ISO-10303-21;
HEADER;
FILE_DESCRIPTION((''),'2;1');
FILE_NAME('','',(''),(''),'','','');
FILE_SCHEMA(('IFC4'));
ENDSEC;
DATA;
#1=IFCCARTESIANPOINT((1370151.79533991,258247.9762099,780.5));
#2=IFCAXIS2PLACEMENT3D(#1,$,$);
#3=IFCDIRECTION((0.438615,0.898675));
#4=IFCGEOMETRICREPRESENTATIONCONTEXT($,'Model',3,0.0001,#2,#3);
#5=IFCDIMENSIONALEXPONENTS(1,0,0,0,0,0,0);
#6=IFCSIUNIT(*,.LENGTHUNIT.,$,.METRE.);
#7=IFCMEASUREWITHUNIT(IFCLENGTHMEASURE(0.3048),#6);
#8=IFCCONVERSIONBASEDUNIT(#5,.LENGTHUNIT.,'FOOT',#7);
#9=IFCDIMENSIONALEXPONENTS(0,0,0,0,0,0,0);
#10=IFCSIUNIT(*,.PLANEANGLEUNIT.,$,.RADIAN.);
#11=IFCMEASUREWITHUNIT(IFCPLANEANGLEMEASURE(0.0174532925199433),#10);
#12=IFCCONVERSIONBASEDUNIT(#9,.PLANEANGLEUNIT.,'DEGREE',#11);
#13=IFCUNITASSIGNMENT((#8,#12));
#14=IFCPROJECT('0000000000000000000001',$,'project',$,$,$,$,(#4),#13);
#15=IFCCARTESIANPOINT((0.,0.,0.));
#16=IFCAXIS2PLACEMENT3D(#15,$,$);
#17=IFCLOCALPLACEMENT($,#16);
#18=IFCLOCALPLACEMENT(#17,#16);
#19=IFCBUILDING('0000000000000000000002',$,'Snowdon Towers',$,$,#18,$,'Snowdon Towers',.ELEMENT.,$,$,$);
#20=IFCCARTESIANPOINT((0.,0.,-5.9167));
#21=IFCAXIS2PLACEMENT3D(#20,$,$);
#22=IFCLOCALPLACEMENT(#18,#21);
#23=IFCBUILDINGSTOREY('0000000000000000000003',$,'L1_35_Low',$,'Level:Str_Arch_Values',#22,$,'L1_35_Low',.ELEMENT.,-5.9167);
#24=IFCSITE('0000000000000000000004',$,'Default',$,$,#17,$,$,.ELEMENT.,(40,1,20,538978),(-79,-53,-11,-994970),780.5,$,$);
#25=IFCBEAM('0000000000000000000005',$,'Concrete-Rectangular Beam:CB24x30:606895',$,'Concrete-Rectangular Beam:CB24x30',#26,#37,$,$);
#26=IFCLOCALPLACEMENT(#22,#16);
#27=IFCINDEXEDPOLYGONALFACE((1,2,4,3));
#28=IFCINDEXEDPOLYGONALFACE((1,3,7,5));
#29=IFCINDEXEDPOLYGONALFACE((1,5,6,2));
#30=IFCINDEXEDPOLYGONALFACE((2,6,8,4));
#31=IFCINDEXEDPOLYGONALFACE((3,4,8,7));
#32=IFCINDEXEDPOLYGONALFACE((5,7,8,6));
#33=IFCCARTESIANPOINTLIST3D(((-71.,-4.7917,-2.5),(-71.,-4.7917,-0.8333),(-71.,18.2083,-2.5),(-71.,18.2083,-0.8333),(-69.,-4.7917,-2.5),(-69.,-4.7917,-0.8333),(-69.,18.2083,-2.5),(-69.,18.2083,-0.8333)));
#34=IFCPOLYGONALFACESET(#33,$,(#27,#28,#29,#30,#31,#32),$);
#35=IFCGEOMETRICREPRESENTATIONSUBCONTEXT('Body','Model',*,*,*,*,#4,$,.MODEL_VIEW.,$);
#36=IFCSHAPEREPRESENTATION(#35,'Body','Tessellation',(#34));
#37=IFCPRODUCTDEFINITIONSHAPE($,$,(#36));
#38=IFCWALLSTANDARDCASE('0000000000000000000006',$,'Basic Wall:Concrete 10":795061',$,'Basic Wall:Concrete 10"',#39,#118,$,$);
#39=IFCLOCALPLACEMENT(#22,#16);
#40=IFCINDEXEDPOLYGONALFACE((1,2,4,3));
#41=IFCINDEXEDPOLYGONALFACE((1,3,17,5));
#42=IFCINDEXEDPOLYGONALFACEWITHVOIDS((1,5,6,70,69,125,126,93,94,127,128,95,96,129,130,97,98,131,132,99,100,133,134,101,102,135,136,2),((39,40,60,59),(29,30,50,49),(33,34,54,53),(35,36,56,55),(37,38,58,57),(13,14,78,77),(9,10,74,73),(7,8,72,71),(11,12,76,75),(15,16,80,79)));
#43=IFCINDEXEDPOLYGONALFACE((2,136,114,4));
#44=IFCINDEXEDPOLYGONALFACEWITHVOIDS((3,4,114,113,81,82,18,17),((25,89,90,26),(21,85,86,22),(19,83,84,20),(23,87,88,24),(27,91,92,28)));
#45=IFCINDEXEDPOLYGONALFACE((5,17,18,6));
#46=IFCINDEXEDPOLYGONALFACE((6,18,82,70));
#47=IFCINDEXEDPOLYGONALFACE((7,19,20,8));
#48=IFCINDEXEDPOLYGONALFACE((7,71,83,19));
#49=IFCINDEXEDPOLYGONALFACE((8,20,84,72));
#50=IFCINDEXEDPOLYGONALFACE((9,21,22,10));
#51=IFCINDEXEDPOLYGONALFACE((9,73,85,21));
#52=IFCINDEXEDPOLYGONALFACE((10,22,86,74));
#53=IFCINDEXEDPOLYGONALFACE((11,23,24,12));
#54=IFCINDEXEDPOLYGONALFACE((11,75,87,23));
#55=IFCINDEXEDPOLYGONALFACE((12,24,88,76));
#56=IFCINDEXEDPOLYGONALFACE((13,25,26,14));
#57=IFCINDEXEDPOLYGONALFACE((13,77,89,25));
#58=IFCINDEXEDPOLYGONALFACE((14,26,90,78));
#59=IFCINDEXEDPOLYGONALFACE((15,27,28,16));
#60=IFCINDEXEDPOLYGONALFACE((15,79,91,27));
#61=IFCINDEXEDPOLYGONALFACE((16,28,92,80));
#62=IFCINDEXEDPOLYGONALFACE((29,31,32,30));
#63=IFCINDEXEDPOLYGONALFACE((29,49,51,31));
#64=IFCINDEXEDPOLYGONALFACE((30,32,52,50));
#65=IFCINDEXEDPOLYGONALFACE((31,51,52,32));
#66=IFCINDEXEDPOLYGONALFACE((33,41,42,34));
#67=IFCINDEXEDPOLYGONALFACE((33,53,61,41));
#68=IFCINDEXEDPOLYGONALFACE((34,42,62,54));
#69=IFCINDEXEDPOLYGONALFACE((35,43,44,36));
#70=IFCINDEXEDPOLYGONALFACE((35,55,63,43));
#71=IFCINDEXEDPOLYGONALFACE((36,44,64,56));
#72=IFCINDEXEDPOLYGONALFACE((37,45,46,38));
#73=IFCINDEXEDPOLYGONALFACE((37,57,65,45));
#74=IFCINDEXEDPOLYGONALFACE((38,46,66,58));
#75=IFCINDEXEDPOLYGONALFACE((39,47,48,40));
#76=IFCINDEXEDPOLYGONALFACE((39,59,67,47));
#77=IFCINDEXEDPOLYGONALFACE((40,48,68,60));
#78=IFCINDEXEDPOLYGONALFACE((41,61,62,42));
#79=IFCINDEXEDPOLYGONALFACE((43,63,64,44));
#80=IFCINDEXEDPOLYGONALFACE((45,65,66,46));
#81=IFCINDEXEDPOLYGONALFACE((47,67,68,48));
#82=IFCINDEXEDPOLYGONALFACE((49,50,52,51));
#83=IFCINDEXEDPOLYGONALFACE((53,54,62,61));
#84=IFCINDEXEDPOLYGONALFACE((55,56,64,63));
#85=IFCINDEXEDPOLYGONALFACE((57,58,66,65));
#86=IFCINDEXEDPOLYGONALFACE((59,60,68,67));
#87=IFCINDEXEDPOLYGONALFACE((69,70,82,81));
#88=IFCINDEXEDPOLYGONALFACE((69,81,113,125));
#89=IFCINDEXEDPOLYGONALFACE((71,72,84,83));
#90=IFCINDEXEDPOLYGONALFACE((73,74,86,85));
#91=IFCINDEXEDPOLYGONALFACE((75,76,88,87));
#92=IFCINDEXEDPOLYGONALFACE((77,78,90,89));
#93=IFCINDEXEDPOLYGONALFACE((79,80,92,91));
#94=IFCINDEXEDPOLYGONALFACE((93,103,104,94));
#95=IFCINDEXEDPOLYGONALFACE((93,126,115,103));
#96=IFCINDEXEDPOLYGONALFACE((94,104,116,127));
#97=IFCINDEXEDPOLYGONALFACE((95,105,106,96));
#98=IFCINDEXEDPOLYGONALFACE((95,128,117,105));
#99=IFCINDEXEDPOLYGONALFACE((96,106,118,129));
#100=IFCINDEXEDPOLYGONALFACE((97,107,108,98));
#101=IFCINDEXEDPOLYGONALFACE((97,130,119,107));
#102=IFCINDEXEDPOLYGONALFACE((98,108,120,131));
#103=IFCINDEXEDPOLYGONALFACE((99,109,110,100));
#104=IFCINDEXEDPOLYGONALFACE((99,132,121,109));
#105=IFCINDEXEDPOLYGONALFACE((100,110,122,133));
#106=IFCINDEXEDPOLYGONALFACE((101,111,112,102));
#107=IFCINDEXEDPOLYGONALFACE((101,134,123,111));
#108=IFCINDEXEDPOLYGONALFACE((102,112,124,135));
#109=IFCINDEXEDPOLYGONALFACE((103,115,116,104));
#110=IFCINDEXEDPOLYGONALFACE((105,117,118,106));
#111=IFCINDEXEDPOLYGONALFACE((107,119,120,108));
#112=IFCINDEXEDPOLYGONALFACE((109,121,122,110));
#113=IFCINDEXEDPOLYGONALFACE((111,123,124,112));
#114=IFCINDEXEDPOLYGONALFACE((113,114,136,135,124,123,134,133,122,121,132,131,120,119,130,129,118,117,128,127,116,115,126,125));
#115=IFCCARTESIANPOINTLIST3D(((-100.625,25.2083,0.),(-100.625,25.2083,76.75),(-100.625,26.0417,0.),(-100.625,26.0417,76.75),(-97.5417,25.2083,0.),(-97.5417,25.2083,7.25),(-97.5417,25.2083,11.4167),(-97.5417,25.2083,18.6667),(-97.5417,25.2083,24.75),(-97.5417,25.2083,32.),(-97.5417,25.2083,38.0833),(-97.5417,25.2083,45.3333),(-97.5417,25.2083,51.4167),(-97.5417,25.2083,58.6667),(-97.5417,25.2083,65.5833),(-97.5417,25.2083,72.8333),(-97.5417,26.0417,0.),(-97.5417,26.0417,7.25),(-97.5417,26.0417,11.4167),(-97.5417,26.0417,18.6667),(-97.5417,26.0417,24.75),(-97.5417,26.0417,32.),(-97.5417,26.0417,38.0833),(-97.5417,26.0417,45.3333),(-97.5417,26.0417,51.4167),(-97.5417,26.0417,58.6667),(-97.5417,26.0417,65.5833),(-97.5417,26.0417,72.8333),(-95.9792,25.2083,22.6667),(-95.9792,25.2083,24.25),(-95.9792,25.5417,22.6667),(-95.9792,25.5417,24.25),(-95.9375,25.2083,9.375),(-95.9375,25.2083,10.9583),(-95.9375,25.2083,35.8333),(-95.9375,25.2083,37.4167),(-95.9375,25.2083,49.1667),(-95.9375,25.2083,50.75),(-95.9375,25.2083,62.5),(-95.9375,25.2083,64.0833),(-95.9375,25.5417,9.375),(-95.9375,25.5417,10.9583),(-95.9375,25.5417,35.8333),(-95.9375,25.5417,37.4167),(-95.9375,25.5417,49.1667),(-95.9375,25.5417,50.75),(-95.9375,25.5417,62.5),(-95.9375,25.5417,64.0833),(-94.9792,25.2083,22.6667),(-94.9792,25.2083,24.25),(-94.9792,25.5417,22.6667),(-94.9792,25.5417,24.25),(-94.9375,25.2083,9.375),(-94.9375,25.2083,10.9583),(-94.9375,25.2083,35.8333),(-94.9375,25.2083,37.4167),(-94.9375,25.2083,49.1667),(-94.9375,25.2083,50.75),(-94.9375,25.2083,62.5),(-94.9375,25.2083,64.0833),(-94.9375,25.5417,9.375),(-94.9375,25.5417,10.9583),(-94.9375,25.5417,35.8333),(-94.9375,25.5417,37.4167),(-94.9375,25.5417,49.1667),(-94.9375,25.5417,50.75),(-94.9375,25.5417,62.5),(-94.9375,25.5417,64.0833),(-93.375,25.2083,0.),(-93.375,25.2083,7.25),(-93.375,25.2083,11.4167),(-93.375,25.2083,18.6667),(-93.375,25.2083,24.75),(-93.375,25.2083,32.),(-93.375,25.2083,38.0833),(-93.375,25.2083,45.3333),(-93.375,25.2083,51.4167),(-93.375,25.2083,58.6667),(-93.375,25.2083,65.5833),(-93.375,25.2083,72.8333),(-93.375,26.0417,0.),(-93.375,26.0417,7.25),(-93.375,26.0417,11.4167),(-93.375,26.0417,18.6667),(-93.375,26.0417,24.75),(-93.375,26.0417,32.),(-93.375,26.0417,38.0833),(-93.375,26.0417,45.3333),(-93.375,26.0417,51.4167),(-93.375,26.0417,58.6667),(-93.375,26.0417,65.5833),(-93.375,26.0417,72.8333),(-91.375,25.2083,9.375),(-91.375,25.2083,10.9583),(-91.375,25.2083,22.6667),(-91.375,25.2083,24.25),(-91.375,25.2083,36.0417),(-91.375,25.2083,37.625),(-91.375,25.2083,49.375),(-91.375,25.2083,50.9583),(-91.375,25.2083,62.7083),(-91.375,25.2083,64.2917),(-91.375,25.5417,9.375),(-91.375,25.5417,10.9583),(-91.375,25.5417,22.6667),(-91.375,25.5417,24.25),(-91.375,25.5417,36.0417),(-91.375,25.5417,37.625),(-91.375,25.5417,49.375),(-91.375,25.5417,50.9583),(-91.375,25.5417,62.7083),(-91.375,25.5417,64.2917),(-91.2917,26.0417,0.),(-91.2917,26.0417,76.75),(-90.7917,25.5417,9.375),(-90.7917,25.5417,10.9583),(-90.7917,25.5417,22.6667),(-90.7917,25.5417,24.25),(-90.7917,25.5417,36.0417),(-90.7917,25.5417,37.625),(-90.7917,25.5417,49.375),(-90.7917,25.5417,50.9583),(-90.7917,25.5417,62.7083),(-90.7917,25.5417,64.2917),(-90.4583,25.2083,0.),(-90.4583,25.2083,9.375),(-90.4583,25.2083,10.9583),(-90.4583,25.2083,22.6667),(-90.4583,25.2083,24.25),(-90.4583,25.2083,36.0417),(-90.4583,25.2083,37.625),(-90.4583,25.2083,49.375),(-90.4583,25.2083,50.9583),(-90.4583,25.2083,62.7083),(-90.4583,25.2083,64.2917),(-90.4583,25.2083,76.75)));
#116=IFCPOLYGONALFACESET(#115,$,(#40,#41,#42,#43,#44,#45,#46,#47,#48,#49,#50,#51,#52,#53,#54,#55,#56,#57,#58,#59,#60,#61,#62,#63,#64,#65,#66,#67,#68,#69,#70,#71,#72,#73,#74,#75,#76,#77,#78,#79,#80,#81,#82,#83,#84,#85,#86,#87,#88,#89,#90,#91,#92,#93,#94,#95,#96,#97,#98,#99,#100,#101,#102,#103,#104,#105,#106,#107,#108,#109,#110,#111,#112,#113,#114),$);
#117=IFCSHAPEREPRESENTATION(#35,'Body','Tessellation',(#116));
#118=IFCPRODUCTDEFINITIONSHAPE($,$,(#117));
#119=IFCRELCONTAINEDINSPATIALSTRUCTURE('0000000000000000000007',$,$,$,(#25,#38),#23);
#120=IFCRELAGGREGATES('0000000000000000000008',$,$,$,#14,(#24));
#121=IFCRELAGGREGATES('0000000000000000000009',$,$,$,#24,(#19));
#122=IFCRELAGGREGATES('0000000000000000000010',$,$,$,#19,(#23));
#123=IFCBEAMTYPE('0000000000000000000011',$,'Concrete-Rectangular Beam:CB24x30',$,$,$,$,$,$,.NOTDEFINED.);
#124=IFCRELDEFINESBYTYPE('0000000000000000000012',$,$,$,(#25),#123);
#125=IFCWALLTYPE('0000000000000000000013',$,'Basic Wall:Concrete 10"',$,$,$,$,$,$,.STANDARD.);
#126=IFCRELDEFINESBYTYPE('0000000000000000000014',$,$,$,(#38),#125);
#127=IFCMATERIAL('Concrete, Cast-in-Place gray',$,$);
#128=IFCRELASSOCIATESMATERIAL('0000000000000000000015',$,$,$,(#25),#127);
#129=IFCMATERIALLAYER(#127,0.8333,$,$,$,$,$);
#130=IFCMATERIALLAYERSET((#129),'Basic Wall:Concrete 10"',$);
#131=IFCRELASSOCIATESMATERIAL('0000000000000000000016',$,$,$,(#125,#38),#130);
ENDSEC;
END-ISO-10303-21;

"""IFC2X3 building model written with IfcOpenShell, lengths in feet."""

from ifc_helpers import new_model, entity, si_unit, converted_unit, direction, frame, frame_2d, origin, place, context, subcontext, project, spatial, polyline, rectangle, outline, extrude, material, layer, layer_set, layer_usage, type_object, element, save


model = new_model("IFC2X3")

# Units and contexts
model_context = context("Model", 3, precision=0.0001, world=frame((1370151.79533991, 258247.9762099, 780.5)), true_north=direction((0.438615, 0.898675)))
body_context = subcontext(model_context, "Body", "Model", "MODEL_VIEW")
ifc_project = project(units=[converted_unit("LENGTHUNIT", "FOOT", entity("IfcLengthMeasure", 0.3048), si_unit("LENGTHUNIT", "METRE"), dimensions=[1, 0, 0, 0, 0, 0, 0]), converted_unit("PLANEANGLEUNIT", "DEGREE", entity("IfcPlaneAngleMeasure", 0.0174532925199433), si_unit("PLANEANGLEUNIT", "RADIAN"), dimensions=[0, 0, 0, 0, 0, 0, 0])], contexts=[model_context])

# Site, building, storey
site_placement = place(None, origin())
site = spatial("IfcSite", under=ifc_project, at=site_placement, Name="Default", CompositionType="ELEMENT", RefLatitude=(40, 1, 20, 538978), RefLongitude=(-79, -53, -11, -994970), RefElevation=780.5)
building_placement = place(site_placement, origin())
building = spatial("IfcBuilding", under=site, at=building_placement, Name="Snowdon Towers", LongName="Snowdon Towers", CompositionType="ELEMENT")
storey_placement = place(building_placement, frame((0.0, 0.0, -5.9167)))
storey = spatial("IfcBuildingStorey", under=building, at=storey_placement, Name="L1_35_Low", ObjectType="Level:Str_Arch_Values", LongName="L1_35_Low", CompositionType="ELEMENT", Elevation=-5.9167)

# Beam
ifc_material_1 = material(Name="Concrete, Cast-in-Place gray")
beam_type_1 = type_object("IfcBeamType", Name="Concrete-Rectangular Beam:CB24x30", PredefinedType="NOTDEFINED")
beam_1_placement = place(storey_placement, frame((-70.0, -5.7917, 0.0), z_axis=(0.0, 0.0, 1.0), x_axis=(0.0, 1.0, 0.0)))
element("IfcBeam", 1, at=beam_1_placement, inside=storey, type_object=beam_type_1, material=ifc_material_1, Name="Concrete-Rectangular Beam:CB24x30:606895", ObjectType="Concrete-Rectangular Beam:CB24x30", context=body_context, shape_type="SweptSolid", body=[
    extrude(rectangle(XDim=1.6667, YDim=2.0, at=frame_2d((0.0, 0.0), x_axis=(1.0, 0.0))), frame((1.0, 0.0, -1.6667), z_axis=(1.0, 0.0, 0.0), x_axis=(0.0, 0.0, -1.0)), (0.0, 0.0, 1.0), 23.0),
])

# Wall, openings
ifc_layer_1 = layer(ifc_material_1, 0.8333)
ifc_layer_set_1 = layer_set([ifc_layer_1], Name="Basic Wall:Concrete 10\"")
ifc_layer_usage_1 = layer_usage(ifc_layer_set_1, "AXIS2", "POSITIVE", -0.4167)
wall_type = type_object("IfcWallType", Name="Basic Wall:Concrete 10\"", PredefinedType="STANDARD", material=ifc_layer_set_1)
wall_placement = place(storey_placement, frame((-90.4583, 25.625, 0.0), z_axis=(0.0, 0.0, 1.0), x_axis=(-1.0, 0.0, 0.0)))
wall = element("IfcWallStandardCase", 2, at=wall_placement, inside=storey, type_object=wall_type, material=ifc_layer_usage_1, Name="Basic Wall:Concrete 10\":795061", ObjectType="Basic Wall:Concrete 10\"", context=body_context, shape_type="SweptSolid", body=[
    extrude(outline(polyline([(0.8333, -0.4167), (9.1667, -0.4167), (10.1667, -0.4167), (10.1667, 0.4167), (9.1667, 0.4167), (0.0, 0.4167), (0.8333, -0.4167)])), origin(), (0.0, 0.0, 1.0), 76.75),
])
opening_1_placement = place(wall_placement, origin())
element("IfcOpeningElement", 3, at=opening_1_placement, cuts=wall, ObjectType="Opening", context=body_context, shape_type="SweptSolid", body=[
    extrude(rectangle(XDim=7.25, YDim=4.1667, at=frame_2d((0.0, 0.0), x_axis=(0.0, 1.0))), frame((5.0, -5.4167, 3.625), z_axis=(0.0, 1.0, 0.0), x_axis=(-1.0, 0.0, 0.0)), (0.0, 0.0, 1.0), 10.0),
])
opening_2_placement = place(wall_placement, origin())
element("IfcOpeningElement", 4, at=opening_2_placement, cuts=wall, ObjectType="Recess", context=body_context, shape_type="SweptSolid", body=[
    extrude(rectangle(XDim=1.5833, YDim=1.0, at=frame_2d((0.0, 0.0), x_axis=(0.0, 1.0))), frame((0.4167, 0.0833, 63.5), z_axis=(0.0, 1.0, 0.0), x_axis=(1.0, 0.0, 0.0)), (0.0, 0.0, 1.0), 0.3333),
])
opening_3_placement = place(wall_placement, origin())
element("IfcOpeningElement", 5, at=opening_3_placement, cuts=wall, ObjectType="Recess", context=body_context, shape_type="SweptSolid", body=[
    extrude(rectangle(XDim=1.5833, YDim=1.0, at=frame_2d((0.0, 0.0), x_axis=(0.0, 1.0))), frame((0.4167, 0.0833, 10.1667), z_axis=(0.0, 1.0, 0.0), x_axis=(1.0, 0.0, 0.0)), (0.0, 0.0, 1.0), 0.3333),
])
opening_4_placement = place(wall_placement, origin())
element("IfcOpeningElement", 6, at=opening_4_placement, cuts=wall, ObjectType="Recess", context=body_context, shape_type="SweptSolid", body=[
    extrude(rectangle(XDim=1.5833, YDim=1.0, at=frame_2d((0.0, 0.0), x_axis=(0.0, 1.0))), frame((0.4167, 0.0833, 23.4583), z_axis=(0.0, 1.0, 0.0), x_axis=(1.0, 0.0, 0.0)), (0.0, 0.0, 1.0), 0.3333),
])
opening_5_placement = place(wall_placement, origin())
element("IfcOpeningElement", 7, at=opening_5_placement, cuts=wall, ObjectType="Recess", context=body_context, shape_type="SweptSolid", body=[
    extrude(rectangle(XDim=1.5833, YDim=1.0, at=frame_2d((0.0, 0.0), x_axis=(0.0, 1.0))), frame((0.4167, 0.0833, 36.8333), z_axis=(0.0, 1.0, 0.0), x_axis=(1.0, 0.0, 0.0)), (0.0, 0.0, 1.0), 0.3333),
])
opening_6_placement = place(wall_placement, origin())
element("IfcOpeningElement", 8, at=opening_6_placement, cuts=wall, ObjectType="Recess", context=body_context, shape_type="SweptSolid", body=[
    extrude(rectangle(XDim=1.5833, YDim=1.0, at=frame_2d((0.0, 0.0), x_axis=(0.0, 1.0))), frame((0.4167, 0.0833, 50.1667), z_axis=(0.0, 1.0, 0.0), x_axis=(1.0, 0.0, 0.0)), (0.0, 0.0, 1.0), 0.3333),
])
opening_7_placement = place(wall_placement, origin())
element("IfcOpeningElement", 9, at=opening_7_placement, cuts=wall, ObjectType="Recess", context=body_context, shape_type="SweptSolid", body=[
    extrude(rectangle(XDim=1.5833, YDim=1.0, at=frame_2d((0.0, 0.0), x_axis=(0.0, 1.0))), frame((4.9792, 0.0833, 63.2917), z_axis=(0.0, 1.0, 0.0), x_axis=(1.0, 0.0, 0.0)), (0.0, 0.0, 1.0), 0.3333),
])
opening_8_placement = place(wall_placement, origin())
element("IfcOpeningElement", 10, at=opening_8_placement, cuts=wall, ObjectType="Opening", context=body_context, shape_type="SweptSolid", body=[
    extrude(rectangle(XDim=7.25, YDim=4.1667, at=frame_2d((0.0, 0.0), x_axis=(0.0, 1.0))), frame((5.0, -5.4167, 69.2083), z_axis=(0.0, 1.0, 0.0), x_axis=(-1.0, 0.0, 0.0)), (0.0, 0.0, 1.0), 10.0),
])
opening_9_placement = place(wall_placement, origin())
element("IfcOpeningElement", 11, at=opening_9_placement, cuts=wall, ObjectType="Opening", context=body_context, shape_type="SweptSolid", body=[
    extrude(rectangle(XDim=7.25, YDim=4.1667, at=frame_2d((0.0, 0.0), x_axis=(0.0, 1.0))), frame((5.0, -5.4167, 28.375), z_axis=(0.0, 1.0, 0.0), x_axis=(-1.0, 0.0, 0.0)), (0.0, 0.0, 1.0), 10.0),
])
opening_10_placement = place(wall_placement, origin())
element("IfcOpeningElement", 12, at=opening_10_placement, cuts=wall, ObjectType="Recess", context=body_context, shape_type="SweptSolid", body=[
    extrude(rectangle(XDim=1.5833, YDim=1.0, at=frame_2d((0.0, 0.0), x_axis=(0.0, 1.0))), frame((5.0208, 0.0833, 23.4583), z_axis=(0.0, 1.0, 0.0), x_axis=(1.0, 0.0, 0.0)), (0.0, 0.0, 1.0), 0.3333),
])
opening_11_placement = place(wall_placement, origin())
element("IfcOpeningElement", 13, at=opening_11_placement, cuts=wall, ObjectType="Opening", context=body_context, shape_type="SweptSolid", body=[
    extrude(rectangle(XDim=7.25, YDim=4.1667, at=frame_2d((0.0, 0.0), x_axis=(0.0, 1.0))), frame((5.0, -5.4167, 15.0417), z_axis=(0.0, 1.0, 0.0), x_axis=(-1.0, 0.0, 0.0)), (0.0, 0.0, 1.0), 10.0),
])
opening_12_placement = place(wall_placement, origin())
element("IfcOpeningElement", 14, at=opening_12_placement, cuts=wall, ObjectType="Opening", context=body_context, shape_type="SweptSolid", body=[
    extrude(rectangle(XDim=7.25, YDim=4.1667, at=frame_2d((0.0, 0.0), x_axis=(0.0, 1.0))), frame((5.0, -5.4167, 41.7083), z_axis=(0.0, 1.0, 0.0), x_axis=(-1.0, 0.0, 0.0)), (0.0, 0.0, 1.0), 10.0),
])
opening_13_placement = place(wall_placement, origin())
element("IfcOpeningElement", 15, at=opening_13_placement, cuts=wall, ObjectType="Opening", context=body_context, shape_type="SweptSolid", body=[
    extrude(rectangle(XDim=7.25, YDim=4.1667, at=frame_2d((0.0, 0.0), x_axis=(0.0, 1.0))), frame((5.0, -5.4167, 55.0417), z_axis=(0.0, 1.0, 0.0), x_axis=(-1.0, 0.0, 0.0)), (0.0, 0.0, 1.0), 10.0),
])
opening_14_placement = place(wall_placement, origin())
element("IfcOpeningElement", 16, at=opening_14_placement, cuts=wall, ObjectType="Recess", context=body_context, shape_type="SweptSolid", body=[
    extrude(rectangle(XDim=1.5833, YDim=1.0, at=frame_2d((0.0, 0.0), x_axis=(0.0, 1.0))), frame((4.9792, 0.0833, 10.1667), z_axis=(0.0, 1.0, 0.0), x_axis=(1.0, 0.0, 0.0)), (0.0, 0.0, 1.0), 0.3333),
])
opening_15_placement = place(wall_placement, origin())
element("IfcOpeningElement", 17, at=opening_15_placement, cuts=wall, ObjectType="Recess", context=body_context, shape_type="SweptSolid", body=[
    extrude(rectangle(XDim=1.5833, YDim=1.0, at=frame_2d((0.0, 0.0), x_axis=(0.0, 1.0))), frame((4.9792, 0.0833, 36.625), z_axis=(0.0, 1.0, 0.0), x_axis=(1.0, 0.0, 0.0)), (0.0, 0.0, 1.0), 0.3333),
])
opening_16_placement = place(wall_placement, origin())
element("IfcOpeningElement", 18, at=opening_16_placement, cuts=wall, ObjectType="Recess", context=body_context, shape_type="SweptSolid", body=[
    extrude(rectangle(XDim=1.5833, YDim=1.0, at=frame_2d((0.0, 0.0), x_axis=(0.0, 1.0))), frame((4.9792, 0.0833, 49.9583), z_axis=(0.0, 1.0, 0.0), x_axis=(1.0, 0.0, 0.0)), (0.0, 0.0, 1.0), 0.3333),
])

save(model, "model.ifc")
